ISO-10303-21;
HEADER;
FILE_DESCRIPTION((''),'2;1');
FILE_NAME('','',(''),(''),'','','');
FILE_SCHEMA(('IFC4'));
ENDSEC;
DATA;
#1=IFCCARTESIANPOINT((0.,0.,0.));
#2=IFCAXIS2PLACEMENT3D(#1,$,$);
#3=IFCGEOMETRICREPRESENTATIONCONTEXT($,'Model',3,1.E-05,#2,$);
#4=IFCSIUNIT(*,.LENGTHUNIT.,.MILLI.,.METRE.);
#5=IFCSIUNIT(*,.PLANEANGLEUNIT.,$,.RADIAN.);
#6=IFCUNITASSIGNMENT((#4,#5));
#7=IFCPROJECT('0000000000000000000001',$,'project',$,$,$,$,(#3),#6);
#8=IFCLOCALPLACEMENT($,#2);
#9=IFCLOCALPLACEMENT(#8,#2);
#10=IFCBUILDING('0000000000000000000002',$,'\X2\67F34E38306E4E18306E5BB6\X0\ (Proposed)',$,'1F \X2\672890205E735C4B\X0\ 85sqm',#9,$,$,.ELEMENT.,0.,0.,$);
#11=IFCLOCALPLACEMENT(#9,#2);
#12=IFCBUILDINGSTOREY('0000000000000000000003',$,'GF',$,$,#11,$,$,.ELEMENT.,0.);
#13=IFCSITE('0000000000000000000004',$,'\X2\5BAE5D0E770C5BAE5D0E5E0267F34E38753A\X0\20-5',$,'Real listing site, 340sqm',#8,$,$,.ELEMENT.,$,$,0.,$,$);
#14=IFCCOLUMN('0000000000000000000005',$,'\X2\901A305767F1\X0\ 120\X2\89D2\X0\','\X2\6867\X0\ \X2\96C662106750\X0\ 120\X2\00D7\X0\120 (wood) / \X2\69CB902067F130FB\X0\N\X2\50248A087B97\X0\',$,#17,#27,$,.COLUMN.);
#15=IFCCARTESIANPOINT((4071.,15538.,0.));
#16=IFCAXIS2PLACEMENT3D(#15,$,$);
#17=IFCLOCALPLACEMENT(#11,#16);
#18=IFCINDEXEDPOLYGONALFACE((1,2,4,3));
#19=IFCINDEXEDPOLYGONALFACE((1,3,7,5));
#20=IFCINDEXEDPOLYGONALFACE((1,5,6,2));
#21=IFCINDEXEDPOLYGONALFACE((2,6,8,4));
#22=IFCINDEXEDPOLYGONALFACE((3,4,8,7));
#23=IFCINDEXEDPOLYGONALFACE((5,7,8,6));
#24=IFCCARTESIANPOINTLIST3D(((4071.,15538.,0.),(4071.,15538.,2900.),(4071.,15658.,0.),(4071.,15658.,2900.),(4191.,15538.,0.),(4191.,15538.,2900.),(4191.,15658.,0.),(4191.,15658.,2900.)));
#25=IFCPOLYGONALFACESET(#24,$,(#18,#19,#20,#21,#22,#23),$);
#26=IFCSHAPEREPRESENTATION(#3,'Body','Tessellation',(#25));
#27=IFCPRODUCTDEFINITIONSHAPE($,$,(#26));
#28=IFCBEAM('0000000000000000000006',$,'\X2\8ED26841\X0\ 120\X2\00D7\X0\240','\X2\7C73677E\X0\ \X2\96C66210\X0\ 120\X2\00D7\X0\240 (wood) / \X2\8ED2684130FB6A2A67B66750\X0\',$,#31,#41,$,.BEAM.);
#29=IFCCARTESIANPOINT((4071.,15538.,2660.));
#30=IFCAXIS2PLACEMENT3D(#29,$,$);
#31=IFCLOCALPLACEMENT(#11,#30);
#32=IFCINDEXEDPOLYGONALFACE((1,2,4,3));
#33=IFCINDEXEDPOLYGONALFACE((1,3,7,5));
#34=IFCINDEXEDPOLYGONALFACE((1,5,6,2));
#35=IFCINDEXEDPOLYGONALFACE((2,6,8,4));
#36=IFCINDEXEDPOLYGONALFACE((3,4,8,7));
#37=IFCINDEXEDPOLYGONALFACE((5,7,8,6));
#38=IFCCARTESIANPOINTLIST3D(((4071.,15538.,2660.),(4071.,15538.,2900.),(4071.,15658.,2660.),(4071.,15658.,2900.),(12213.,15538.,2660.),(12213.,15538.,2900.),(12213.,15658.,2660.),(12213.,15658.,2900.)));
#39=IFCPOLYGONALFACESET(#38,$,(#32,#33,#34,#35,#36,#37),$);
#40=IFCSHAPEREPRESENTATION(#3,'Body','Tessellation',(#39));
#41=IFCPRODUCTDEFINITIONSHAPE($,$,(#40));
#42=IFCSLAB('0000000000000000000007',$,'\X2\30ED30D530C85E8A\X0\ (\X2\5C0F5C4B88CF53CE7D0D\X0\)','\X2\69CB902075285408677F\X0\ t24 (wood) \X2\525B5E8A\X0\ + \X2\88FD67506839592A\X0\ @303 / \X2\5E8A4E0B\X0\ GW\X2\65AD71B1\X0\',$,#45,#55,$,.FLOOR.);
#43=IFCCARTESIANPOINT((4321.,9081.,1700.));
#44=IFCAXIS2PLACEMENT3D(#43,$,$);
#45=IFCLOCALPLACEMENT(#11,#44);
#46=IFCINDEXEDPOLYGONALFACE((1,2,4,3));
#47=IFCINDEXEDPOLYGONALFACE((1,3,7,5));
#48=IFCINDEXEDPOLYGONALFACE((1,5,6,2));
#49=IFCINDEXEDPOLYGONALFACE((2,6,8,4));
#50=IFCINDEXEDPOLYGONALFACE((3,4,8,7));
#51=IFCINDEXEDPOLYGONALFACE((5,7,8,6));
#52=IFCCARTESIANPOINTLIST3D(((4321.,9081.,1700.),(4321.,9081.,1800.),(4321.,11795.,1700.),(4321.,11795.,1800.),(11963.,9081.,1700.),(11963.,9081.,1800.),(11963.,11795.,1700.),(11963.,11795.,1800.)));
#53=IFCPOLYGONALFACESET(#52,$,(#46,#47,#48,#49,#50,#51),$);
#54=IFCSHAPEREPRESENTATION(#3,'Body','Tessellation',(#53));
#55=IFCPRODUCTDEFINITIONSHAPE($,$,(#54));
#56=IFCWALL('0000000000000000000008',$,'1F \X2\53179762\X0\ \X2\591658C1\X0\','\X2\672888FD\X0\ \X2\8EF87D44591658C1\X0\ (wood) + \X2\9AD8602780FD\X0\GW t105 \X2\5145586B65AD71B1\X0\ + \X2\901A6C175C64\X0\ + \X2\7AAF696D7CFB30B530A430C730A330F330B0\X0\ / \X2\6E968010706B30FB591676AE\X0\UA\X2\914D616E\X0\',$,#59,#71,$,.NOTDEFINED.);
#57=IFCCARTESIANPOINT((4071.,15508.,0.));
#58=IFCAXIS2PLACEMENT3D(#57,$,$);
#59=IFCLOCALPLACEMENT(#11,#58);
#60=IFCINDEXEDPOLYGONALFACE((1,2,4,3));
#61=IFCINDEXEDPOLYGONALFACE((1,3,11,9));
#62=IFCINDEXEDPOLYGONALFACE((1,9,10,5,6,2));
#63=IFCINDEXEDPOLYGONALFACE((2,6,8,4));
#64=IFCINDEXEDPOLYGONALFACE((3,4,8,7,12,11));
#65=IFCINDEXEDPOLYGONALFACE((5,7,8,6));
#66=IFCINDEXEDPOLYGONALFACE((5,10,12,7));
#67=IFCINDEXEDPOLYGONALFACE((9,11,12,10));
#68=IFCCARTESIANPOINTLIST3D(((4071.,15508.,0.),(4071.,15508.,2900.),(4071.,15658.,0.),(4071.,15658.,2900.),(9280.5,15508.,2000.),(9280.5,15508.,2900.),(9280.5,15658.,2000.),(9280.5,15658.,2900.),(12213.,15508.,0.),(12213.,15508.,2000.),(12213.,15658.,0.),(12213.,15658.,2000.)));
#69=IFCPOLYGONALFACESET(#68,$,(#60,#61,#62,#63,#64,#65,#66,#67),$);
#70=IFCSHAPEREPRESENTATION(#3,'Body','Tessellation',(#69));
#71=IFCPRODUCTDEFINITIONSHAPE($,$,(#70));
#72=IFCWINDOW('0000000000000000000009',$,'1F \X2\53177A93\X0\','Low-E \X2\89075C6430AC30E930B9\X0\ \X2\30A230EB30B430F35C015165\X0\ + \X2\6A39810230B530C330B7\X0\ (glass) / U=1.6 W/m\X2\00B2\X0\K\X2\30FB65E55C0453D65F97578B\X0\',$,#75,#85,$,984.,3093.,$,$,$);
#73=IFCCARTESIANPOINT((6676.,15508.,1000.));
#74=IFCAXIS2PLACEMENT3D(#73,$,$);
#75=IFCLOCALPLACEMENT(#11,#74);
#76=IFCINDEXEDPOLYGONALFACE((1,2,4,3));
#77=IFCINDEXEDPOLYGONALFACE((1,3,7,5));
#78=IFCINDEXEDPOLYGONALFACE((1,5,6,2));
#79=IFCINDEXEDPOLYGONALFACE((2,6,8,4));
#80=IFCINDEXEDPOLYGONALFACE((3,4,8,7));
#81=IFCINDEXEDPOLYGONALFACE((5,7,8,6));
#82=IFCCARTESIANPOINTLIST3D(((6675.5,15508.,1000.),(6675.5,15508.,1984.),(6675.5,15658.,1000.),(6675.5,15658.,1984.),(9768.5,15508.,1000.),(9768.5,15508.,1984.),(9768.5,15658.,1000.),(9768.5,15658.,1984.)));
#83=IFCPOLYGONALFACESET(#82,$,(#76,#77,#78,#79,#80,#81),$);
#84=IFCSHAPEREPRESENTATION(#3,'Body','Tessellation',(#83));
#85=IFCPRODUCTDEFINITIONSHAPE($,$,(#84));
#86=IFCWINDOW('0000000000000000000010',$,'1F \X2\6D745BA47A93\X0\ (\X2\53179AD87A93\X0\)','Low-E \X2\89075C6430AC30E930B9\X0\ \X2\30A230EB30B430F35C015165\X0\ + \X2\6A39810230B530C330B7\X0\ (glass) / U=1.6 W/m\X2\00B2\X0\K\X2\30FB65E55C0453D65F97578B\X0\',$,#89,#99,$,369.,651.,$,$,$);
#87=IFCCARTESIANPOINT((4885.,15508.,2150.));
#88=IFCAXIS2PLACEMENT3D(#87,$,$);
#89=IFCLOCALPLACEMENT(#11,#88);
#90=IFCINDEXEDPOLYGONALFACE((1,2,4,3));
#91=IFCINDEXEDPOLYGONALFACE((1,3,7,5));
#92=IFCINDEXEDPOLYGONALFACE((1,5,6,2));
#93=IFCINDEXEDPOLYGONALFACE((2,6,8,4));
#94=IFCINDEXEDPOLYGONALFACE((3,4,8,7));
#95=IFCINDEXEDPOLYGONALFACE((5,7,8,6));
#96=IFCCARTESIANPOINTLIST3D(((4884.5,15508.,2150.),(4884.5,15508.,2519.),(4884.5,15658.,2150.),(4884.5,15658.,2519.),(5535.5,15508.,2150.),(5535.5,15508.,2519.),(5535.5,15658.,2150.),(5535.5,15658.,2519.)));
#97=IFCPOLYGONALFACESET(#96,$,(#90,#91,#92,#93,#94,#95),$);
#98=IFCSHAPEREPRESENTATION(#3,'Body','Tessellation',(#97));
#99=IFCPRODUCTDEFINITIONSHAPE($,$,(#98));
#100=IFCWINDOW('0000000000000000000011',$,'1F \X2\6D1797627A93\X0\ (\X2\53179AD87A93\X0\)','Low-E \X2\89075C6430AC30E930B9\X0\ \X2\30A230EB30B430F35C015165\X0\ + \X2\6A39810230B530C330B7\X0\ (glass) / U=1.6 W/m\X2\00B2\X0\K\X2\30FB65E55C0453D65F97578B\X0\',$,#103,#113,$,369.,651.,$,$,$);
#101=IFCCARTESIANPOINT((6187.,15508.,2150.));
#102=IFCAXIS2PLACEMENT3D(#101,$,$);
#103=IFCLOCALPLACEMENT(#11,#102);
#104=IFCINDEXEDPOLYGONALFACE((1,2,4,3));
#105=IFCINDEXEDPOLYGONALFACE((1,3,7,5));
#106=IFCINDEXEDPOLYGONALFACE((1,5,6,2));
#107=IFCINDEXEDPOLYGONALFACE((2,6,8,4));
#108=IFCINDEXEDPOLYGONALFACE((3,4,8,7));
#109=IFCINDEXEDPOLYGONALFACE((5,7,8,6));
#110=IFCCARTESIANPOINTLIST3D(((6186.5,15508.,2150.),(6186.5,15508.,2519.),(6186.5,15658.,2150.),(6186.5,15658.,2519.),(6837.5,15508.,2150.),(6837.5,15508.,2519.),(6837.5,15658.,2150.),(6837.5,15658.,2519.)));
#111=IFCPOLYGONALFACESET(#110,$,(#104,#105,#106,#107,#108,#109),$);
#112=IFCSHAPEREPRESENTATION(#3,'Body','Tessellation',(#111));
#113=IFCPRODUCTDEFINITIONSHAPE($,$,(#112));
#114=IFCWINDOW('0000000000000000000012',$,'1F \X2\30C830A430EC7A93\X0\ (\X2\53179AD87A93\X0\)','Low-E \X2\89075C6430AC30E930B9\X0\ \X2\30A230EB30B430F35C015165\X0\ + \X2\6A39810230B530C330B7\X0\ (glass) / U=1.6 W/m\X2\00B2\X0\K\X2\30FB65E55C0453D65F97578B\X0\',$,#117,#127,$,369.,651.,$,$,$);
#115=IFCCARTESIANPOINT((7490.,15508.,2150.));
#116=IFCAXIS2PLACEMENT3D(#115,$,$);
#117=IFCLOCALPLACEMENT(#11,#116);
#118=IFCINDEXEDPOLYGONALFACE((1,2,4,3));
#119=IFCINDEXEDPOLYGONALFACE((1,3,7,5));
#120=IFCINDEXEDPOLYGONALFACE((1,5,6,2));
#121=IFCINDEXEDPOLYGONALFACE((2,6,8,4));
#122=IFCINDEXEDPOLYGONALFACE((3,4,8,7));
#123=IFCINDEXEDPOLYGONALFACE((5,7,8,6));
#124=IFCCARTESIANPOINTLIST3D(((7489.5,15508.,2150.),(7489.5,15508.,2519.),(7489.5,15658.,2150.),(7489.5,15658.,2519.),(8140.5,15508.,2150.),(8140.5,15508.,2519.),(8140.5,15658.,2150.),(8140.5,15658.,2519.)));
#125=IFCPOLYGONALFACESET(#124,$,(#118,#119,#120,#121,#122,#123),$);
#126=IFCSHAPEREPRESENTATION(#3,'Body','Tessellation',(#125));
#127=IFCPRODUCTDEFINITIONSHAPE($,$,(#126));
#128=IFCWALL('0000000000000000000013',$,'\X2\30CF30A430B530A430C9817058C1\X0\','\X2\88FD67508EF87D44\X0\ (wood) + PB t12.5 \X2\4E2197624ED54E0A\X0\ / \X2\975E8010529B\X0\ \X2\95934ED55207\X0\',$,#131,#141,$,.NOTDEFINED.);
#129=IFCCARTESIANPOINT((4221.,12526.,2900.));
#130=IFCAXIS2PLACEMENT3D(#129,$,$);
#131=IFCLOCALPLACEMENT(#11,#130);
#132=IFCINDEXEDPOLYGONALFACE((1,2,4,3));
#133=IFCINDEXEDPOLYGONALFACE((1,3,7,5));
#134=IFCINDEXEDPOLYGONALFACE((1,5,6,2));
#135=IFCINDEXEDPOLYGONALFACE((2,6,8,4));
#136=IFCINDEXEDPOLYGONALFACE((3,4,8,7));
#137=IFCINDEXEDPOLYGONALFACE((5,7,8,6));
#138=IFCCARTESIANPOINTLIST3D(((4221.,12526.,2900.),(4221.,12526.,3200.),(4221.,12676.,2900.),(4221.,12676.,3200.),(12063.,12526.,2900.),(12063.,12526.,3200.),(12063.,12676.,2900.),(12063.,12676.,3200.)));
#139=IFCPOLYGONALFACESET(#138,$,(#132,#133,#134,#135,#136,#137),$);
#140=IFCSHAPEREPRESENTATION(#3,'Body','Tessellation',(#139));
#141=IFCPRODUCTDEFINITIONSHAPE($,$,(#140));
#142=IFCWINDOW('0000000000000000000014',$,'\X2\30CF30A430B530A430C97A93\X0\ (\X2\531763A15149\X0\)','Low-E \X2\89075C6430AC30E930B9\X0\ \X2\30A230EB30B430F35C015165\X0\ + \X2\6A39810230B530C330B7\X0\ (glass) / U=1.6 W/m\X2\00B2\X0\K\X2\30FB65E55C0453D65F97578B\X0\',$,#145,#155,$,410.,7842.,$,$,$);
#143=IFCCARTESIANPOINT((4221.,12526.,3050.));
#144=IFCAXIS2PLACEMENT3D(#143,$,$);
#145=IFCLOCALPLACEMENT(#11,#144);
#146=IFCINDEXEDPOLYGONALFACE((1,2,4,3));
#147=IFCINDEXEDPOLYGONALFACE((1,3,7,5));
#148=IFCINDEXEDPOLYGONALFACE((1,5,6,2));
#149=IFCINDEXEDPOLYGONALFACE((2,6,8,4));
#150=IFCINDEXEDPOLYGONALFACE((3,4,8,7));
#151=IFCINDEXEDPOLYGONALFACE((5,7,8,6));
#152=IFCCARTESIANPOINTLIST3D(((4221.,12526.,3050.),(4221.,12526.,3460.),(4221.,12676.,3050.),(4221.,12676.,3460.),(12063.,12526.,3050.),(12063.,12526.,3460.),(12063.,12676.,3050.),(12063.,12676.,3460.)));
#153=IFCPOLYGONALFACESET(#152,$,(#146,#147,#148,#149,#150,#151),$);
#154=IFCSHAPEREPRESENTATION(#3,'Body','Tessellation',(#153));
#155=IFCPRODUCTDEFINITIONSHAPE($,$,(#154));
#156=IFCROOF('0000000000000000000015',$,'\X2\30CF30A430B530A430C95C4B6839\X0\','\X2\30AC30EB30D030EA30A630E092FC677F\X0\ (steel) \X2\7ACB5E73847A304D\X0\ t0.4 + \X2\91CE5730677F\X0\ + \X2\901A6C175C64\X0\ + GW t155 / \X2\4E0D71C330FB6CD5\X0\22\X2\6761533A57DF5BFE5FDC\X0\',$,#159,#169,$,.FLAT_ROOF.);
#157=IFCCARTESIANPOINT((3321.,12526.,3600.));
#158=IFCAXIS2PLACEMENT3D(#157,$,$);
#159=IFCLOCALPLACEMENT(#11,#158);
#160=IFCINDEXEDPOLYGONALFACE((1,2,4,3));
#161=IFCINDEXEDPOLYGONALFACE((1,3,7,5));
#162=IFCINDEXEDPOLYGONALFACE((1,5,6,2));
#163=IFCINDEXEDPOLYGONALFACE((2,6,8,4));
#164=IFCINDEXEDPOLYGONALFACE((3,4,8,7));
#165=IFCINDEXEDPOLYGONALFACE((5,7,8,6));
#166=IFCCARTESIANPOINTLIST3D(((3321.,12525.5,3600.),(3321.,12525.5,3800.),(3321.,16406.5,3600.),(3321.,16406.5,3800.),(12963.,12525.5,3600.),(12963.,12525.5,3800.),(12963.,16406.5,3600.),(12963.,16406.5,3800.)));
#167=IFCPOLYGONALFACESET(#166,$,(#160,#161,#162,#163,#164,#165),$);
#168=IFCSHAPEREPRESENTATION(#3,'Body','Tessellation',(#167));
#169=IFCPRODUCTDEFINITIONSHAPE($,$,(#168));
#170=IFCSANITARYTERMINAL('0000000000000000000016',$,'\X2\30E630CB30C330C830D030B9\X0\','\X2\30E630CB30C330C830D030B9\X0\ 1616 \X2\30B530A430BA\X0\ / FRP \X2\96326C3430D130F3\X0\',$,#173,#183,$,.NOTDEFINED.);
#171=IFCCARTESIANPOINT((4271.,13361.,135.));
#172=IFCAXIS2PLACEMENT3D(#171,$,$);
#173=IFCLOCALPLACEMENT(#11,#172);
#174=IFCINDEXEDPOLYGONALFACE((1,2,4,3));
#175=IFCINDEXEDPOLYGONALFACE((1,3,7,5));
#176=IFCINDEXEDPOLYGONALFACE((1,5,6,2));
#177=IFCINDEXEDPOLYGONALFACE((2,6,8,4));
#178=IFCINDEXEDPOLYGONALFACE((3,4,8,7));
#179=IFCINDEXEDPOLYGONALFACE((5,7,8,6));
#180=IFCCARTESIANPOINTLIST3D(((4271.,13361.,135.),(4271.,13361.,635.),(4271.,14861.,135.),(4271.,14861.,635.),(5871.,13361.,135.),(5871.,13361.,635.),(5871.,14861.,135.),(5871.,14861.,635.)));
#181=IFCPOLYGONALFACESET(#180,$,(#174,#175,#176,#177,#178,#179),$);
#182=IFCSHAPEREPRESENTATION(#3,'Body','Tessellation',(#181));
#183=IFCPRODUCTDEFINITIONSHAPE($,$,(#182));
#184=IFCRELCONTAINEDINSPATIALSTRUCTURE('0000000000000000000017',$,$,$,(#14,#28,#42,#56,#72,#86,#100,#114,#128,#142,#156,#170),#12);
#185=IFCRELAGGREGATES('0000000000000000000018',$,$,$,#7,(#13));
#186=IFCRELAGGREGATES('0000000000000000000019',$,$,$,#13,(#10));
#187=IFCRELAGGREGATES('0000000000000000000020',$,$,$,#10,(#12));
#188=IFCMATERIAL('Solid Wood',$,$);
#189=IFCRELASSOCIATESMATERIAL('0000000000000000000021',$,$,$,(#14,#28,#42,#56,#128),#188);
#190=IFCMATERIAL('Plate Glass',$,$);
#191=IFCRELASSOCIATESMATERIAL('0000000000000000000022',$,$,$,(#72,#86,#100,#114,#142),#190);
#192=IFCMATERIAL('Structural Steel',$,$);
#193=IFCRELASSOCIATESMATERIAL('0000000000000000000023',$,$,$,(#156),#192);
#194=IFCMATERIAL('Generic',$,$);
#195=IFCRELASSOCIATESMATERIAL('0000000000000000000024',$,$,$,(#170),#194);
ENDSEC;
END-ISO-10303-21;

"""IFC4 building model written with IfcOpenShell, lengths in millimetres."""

from ifc_helpers import new_model, si_unit, frame, frame_2d, origin, place, context, project, spatial, rectangle, extrude, material, element, fill, save


model = new_model("IFC4")

# Units and contexts
model_context = context("Model", 3, precision=1e-05, world=origin())
ifc_project = project(units=[si_unit("LENGTHUNIT", "METRE", prefix="MILLI"), si_unit("PLANEANGLEUNIT", "RADIAN")], contexts=[model_context])

# Site, building, storey
site_placement = place(None, origin())
site = spatial("IfcSite", under=ifc_project, at=site_placement, Name="宮崎県宮崎市柳丸町20-5", ObjectType="Real listing site, 340sqm", CompositionType="ELEMENT", RefElevation=0.0)
building_placement = place(site_placement, origin())
building = spatial("IfcBuilding", under=site, at=building_placement, Name="柳丸の丘の家 (Proposed)", ObjectType="1F 木造平屋 85sqm", CompositionType="ELEMENT", ElevationOfRefHeight=0.0, ElevationOfTerrain=0.0)
storey_placement = place(building_placement, origin())
storey = spatial("IfcBuildingStorey", under=building, at=storey_placement, Name="GF", CompositionType="ELEMENT", Elevation=0.0)

# Column
ifc_material_1 = material(Name="Solid Wood")
column_1_placement = place(storey_placement, frame((4071.0, 15538.0, 0.0)))
element("IfcColumn", 1, at=column_1_placement, inside=storey, material=ifc_material_1, Name="通し柱 120角", Description="桧 集成材 120×120 (wood) / 構造柱・N値計算", PredefinedType="COLUMN", context=model_context, shape_type="SweptSolid", body=[
    extrude(rectangle(XDim=120.0, YDim=120.0, at=frame_2d((60.0, 60.0))), frame((4071.0, 15538.0, 0.0)), (0.0, 0.0, 1.0), 2900.0),
])

# Beam
beam_1_placement = place(storey_placement, frame((4071.0, 15538.0, 2660.0)))
element("IfcBeam", 2, at=beam_1_placement, inside=storey, material=ifc_material_1, Name="軒桁 120×240", Description="米松 集成 120×240 (wood) / 軒桁・横架材", PredefinedType="BEAM", context=model_context, shape_type="SweptSolid", body=[
    extrude(rectangle(XDim=8142.0, YDim=120.0, at=frame_2d((4071.0, 60.0))), frame((4071.0, 15538.0, 2660.0)), (0.0, 0.0, 1.0), 240.0),
])

# Slab
slab_placement = place(storey_placement, frame((4321.0, 9081.0, 1700.0)))
element("IfcSlab", 3, at=slab_placement, inside=storey, material=ifc_material_1, Name="ロフト床 (小屋裏収納)", Description="構造用合板 t24 (wood) 剛床 + 製材根太 @303 / 床下 GW断熱", PredefinedType="FLOOR", context=model_context, shape_type="SweptSolid", body=[
    extrude(rectangle(XDim=7642.0, YDim=2714.0, at=frame_2d((3821.0, 1357.0))), frame((4321.0, 9081.0, 1700.0)), (0.0, 0.0, 1.0), 100.0),
])

# Wall, openings, windows
wall_1_placement = place(storey_placement, frame((4071.0, 15508.0, 0.0)))
wall_1 = element("IfcWall", 4, at=wall_1_placement, inside=storey, material=ifc_material_1, Name="1F 北面 外壁", Description="木製 軸組外壁 (wood) + 高性能GW t105 充填断熱 + 通気層 + 窯業系サイディング / 準耐火・外皮UA配慮", PredefinedType="NOTDEFINED", context=model_context, shape_type="SweptSolid", body=[
    extrude(rectangle(XDim=8142.0, YDim=150.0, at=frame_2d((4071.0, 75.0))), frame((4071.0, 15508.0, 0.0)), (0.0, 0.0, 1.0), 2900.0),
])
opening_1_placement = place(storey_placement, frame((6676.0, 15508.0, 1000.0)))
opening_1 = element("IfcOpeningElement", 5, at=opening_1_placement, cuts=wall_1, PredefinedType="NOTDEFINED", context=model_context, shape_type="SweptSolid", body=[
    extrude(rectangle(XDim=3093.0, YDim=150.0, at=frame_2d((1546.0, 75.0))), frame((6676.0, 15508.0, 1000.0)), (0.0, 0.0, 1.0), 984.0),
])
opening_2_placement = place(storey_placement, frame((4885.0, 15508.0, 2150.0)))
opening_2 = element("IfcOpeningElement", 6, at=opening_2_placement, cuts=wall_1, PredefinedType="NOTDEFINED", context=model_context, shape_type="SweptSolid", body=[
    extrude(rectangle(XDim=651.0, YDim=150.0, at=frame_2d((325.0, 75.0))), frame((4885.0, 15508.0, 2150.0)), (0.0, 0.0, 1.0), 369.0),
])
opening_3_placement = place(storey_placement, frame((6187.0, 15508.0, 2150.0)))
opening_3 = element("IfcOpeningElement", 7, at=opening_3_placement, cuts=wall_1, PredefinedType="NOTDEFINED", context=model_context, shape_type="SweptSolid", body=[
    extrude(rectangle(XDim=651.0, YDim=150.0, at=frame_2d((325.0, 75.0))), frame((6187.0, 15508.0, 2150.0)), (0.0, 0.0, 1.0), 369.0),
])
opening_4_placement = place(storey_placement, frame((7490.0, 15508.0, 2150.0)))
opening_4 = element("IfcOpeningElement", 8, at=opening_4_placement, cuts=wall_1, PredefinedType="NOTDEFINED", context=model_context, shape_type="SweptSolid", body=[
    extrude(rectangle(XDim=651.0, YDim=150.0, at=frame_2d((325.0, 75.0))), frame((7490.0, 15508.0, 2150.0)), (0.0, 0.0, 1.0), 369.0),
])
ifc_material_2 = material(Name="Plate Glass")
window_1_placement = place(storey_placement, frame((6676.0, 15508.0, 1000.0)))
window_1 = element("IfcWindow", 9, at=window_1_placement, inside=storey, material=ifc_material_2, Name="1F 北窓", Description="Low-E 複層ガラス アルゴン封入 + 樹脂サッシ (glass) / U=1.6 W/m²K・日射取得型", OverallHeight=984.0, OverallWidth=3093.0, context=model_context, shape_type="SweptSolid", body=[
    extrude(rectangle(XDim=3093.0, YDim=150.0, at=frame_2d((1546.0, 75.0))), frame((6676.0, 15508.0, 1000.0)), (0.0, 0.0, 1.0), 984.0),
])
fill(opening_1, window_1)
window_2_placement = place(storey_placement, frame((4885.0, 15508.0, 2150.0)))
window_2 = element("IfcWindow", 10, at=window_2_placement, inside=storey, material=ifc_material_2, Name="1F 浴室窓 (北高窓)", Description="Low-E 複層ガラス アルゴン封入 + 樹脂サッシ (glass) / U=1.6 W/m²K・日射取得型", OverallHeight=369.0, OverallWidth=651.0, context=model_context, shape_type="SweptSolid", body=[
    extrude(rectangle(XDim=651.0, YDim=150.0, at=frame_2d((325.0, 75.0))), frame((4885.0, 15508.0, 2150.0)), (0.0, 0.0, 1.0), 369.0),
])
fill(opening_2, window_2)
window_3_placement = place(storey_placement, frame((6187.0, 15508.0, 2150.0)))
window_3 = element("IfcWindow", 11, at=window_3_placement, inside=storey, material=ifc_material_2, Name="1F 洗面窓 (北高窓)", Description="Low-E 複層ガラス アルゴン封入 + 樹脂サッシ (glass) / U=1.6 W/m²K・日射取得型", OverallHeight=369.0, OverallWidth=651.0, context=model_context, shape_type="SweptSolid", body=[
    extrude(rectangle(XDim=651.0, YDim=150.0, at=frame_2d((325.0, 75.0))), frame((6187.0, 15508.0, 2150.0)), (0.0, 0.0, 1.0), 369.0),
])
fill(opening_3, window_3)
window_4_placement = place(storey_placement, frame((7490.0, 15508.0, 2150.0)))
window_4 = element("IfcWindow", 12, at=window_4_placement, inside=storey, material=ifc_material_2, Name="1F トイレ窓 (北高窓)", Description="Low-E 複層ガラス アルゴン封入 + 樹脂サッシ (glass) / U=1.6 W/m²K・日射取得型", OverallHeight=369.0, OverallWidth=651.0, context=model_context, shape_type="SweptSolid", body=[
    extrude(rectangle(XDim=651.0, YDim=150.0, at=frame_2d((325.0, 75.0))), frame((7490.0, 15508.0, 2150.0)), (0.0, 0.0, 1.0), 369.0),
])
fill(opening_4, window_4)

# Wall, opening, window
wall_2_placement = place(storey_placement, frame((4221.0, 12526.0, 2900.0)))
wall_2 = element("IfcWall", 13, at=wall_2_placement, inside=storey, material=ifc_material_1, Name="ハイサイド腰壁", Description="製材軸組 (wood) + PB t12.5 両面仕上 / 非耐力 間仕切", PredefinedType="NOTDEFINED", context=model_context, shape_type="SweptSolid", body=[
    extrude(rectangle(XDim=7842.0, YDim=150.0, at=frame_2d((3921.0, 75.0))), frame((4221.0, 12526.0, 2900.0)), (0.0, 0.0, 1.0), 700.0),
])
opening_5_placement = place(storey_placement, frame((4221.0, 12526.0, 3050.0)))
opening_5 = element("IfcOpeningElement", 14, at=opening_5_placement, cuts=wall_2, PredefinedType="NOTDEFINED", context=model_context, shape_type="SweptSolid", body=[
    extrude(rectangle(XDim=7842.0, YDim=150.0, at=frame_2d((3921.0, 75.0))), frame((4221.0, 12526.0, 3050.0)), (0.0, 0.0, 1.0), 410.0),
])
window_5_placement = place(storey_placement, frame((4221.0, 12526.0, 3050.0)))
window_5 = element("IfcWindow", 15, at=window_5_placement, inside=storey, material=ifc_material_2, Name="ハイサイド窓 (北採光)", Description="Low-E 複層ガラス アルゴン封入 + 樹脂サッシ (glass) / U=1.6 W/m²K・日射取得型", OverallHeight=410.0, OverallWidth=7842.0, context=model_context, shape_type="SweptSolid", body=[
    extrude(rectangle(XDim=7842.0, YDim=150.0, at=frame_2d((3921.0, 75.0))), frame((4221.0, 12526.0, 3050.0)), (0.0, 0.0, 1.0), 410.0),
])
fill(opening_5, window_5)

# Roof
ifc_material_3 = material(Name="Structural Steel")
roof_placement = place(storey_placement, frame((3321.0, 12526.0, 3600.0)))
element("IfcRoof", 16, at=roof_placement, inside=storey, material=ifc_material_3, Name="ハイサイド屋根", Description="ガルバリウム鋼板 (steel) 立平葺き t0.4 + 野地板 + 通気層 + GW t155 / 不燃・法22条区域対応", PredefinedType="FLAT_ROOF", context=model_context, shape_type="SweptSolid", body=[
    extrude(rectangle(XDim=9642.0, YDim=3881.0, at=frame_2d((4821.0, 1940.0))), frame((3321.0, 12526.0, 3600.0)), (0.0, 0.0, 1.0), 200.0),
])

# Sanitary terminal
ifc_material_4 = material(Name="Generic")
sanitary_terminal_placement = place(storey_placement, frame((4271.0, 13361.0, 135.0)))
element("IfcSanitaryTerminal", 17, at=sanitary_terminal_placement, inside=storey, material=ifc_material_4, Name="ユニットバス", Description="ユニットバス 1616 サイズ / FRP 防水パン", PredefinedType="NOTDEFINED", context=model_context, shape_type="SweptSolid", body=[
    extrude(rectangle(XDim=1600.0, YDim=1500.0, at=frame_2d((800.0, 750.0))), frame((4271.0, 13361.0, 135.0)), (0.0, 0.0, 1.0), 500.0),
])

save(model, "model.ifc")
